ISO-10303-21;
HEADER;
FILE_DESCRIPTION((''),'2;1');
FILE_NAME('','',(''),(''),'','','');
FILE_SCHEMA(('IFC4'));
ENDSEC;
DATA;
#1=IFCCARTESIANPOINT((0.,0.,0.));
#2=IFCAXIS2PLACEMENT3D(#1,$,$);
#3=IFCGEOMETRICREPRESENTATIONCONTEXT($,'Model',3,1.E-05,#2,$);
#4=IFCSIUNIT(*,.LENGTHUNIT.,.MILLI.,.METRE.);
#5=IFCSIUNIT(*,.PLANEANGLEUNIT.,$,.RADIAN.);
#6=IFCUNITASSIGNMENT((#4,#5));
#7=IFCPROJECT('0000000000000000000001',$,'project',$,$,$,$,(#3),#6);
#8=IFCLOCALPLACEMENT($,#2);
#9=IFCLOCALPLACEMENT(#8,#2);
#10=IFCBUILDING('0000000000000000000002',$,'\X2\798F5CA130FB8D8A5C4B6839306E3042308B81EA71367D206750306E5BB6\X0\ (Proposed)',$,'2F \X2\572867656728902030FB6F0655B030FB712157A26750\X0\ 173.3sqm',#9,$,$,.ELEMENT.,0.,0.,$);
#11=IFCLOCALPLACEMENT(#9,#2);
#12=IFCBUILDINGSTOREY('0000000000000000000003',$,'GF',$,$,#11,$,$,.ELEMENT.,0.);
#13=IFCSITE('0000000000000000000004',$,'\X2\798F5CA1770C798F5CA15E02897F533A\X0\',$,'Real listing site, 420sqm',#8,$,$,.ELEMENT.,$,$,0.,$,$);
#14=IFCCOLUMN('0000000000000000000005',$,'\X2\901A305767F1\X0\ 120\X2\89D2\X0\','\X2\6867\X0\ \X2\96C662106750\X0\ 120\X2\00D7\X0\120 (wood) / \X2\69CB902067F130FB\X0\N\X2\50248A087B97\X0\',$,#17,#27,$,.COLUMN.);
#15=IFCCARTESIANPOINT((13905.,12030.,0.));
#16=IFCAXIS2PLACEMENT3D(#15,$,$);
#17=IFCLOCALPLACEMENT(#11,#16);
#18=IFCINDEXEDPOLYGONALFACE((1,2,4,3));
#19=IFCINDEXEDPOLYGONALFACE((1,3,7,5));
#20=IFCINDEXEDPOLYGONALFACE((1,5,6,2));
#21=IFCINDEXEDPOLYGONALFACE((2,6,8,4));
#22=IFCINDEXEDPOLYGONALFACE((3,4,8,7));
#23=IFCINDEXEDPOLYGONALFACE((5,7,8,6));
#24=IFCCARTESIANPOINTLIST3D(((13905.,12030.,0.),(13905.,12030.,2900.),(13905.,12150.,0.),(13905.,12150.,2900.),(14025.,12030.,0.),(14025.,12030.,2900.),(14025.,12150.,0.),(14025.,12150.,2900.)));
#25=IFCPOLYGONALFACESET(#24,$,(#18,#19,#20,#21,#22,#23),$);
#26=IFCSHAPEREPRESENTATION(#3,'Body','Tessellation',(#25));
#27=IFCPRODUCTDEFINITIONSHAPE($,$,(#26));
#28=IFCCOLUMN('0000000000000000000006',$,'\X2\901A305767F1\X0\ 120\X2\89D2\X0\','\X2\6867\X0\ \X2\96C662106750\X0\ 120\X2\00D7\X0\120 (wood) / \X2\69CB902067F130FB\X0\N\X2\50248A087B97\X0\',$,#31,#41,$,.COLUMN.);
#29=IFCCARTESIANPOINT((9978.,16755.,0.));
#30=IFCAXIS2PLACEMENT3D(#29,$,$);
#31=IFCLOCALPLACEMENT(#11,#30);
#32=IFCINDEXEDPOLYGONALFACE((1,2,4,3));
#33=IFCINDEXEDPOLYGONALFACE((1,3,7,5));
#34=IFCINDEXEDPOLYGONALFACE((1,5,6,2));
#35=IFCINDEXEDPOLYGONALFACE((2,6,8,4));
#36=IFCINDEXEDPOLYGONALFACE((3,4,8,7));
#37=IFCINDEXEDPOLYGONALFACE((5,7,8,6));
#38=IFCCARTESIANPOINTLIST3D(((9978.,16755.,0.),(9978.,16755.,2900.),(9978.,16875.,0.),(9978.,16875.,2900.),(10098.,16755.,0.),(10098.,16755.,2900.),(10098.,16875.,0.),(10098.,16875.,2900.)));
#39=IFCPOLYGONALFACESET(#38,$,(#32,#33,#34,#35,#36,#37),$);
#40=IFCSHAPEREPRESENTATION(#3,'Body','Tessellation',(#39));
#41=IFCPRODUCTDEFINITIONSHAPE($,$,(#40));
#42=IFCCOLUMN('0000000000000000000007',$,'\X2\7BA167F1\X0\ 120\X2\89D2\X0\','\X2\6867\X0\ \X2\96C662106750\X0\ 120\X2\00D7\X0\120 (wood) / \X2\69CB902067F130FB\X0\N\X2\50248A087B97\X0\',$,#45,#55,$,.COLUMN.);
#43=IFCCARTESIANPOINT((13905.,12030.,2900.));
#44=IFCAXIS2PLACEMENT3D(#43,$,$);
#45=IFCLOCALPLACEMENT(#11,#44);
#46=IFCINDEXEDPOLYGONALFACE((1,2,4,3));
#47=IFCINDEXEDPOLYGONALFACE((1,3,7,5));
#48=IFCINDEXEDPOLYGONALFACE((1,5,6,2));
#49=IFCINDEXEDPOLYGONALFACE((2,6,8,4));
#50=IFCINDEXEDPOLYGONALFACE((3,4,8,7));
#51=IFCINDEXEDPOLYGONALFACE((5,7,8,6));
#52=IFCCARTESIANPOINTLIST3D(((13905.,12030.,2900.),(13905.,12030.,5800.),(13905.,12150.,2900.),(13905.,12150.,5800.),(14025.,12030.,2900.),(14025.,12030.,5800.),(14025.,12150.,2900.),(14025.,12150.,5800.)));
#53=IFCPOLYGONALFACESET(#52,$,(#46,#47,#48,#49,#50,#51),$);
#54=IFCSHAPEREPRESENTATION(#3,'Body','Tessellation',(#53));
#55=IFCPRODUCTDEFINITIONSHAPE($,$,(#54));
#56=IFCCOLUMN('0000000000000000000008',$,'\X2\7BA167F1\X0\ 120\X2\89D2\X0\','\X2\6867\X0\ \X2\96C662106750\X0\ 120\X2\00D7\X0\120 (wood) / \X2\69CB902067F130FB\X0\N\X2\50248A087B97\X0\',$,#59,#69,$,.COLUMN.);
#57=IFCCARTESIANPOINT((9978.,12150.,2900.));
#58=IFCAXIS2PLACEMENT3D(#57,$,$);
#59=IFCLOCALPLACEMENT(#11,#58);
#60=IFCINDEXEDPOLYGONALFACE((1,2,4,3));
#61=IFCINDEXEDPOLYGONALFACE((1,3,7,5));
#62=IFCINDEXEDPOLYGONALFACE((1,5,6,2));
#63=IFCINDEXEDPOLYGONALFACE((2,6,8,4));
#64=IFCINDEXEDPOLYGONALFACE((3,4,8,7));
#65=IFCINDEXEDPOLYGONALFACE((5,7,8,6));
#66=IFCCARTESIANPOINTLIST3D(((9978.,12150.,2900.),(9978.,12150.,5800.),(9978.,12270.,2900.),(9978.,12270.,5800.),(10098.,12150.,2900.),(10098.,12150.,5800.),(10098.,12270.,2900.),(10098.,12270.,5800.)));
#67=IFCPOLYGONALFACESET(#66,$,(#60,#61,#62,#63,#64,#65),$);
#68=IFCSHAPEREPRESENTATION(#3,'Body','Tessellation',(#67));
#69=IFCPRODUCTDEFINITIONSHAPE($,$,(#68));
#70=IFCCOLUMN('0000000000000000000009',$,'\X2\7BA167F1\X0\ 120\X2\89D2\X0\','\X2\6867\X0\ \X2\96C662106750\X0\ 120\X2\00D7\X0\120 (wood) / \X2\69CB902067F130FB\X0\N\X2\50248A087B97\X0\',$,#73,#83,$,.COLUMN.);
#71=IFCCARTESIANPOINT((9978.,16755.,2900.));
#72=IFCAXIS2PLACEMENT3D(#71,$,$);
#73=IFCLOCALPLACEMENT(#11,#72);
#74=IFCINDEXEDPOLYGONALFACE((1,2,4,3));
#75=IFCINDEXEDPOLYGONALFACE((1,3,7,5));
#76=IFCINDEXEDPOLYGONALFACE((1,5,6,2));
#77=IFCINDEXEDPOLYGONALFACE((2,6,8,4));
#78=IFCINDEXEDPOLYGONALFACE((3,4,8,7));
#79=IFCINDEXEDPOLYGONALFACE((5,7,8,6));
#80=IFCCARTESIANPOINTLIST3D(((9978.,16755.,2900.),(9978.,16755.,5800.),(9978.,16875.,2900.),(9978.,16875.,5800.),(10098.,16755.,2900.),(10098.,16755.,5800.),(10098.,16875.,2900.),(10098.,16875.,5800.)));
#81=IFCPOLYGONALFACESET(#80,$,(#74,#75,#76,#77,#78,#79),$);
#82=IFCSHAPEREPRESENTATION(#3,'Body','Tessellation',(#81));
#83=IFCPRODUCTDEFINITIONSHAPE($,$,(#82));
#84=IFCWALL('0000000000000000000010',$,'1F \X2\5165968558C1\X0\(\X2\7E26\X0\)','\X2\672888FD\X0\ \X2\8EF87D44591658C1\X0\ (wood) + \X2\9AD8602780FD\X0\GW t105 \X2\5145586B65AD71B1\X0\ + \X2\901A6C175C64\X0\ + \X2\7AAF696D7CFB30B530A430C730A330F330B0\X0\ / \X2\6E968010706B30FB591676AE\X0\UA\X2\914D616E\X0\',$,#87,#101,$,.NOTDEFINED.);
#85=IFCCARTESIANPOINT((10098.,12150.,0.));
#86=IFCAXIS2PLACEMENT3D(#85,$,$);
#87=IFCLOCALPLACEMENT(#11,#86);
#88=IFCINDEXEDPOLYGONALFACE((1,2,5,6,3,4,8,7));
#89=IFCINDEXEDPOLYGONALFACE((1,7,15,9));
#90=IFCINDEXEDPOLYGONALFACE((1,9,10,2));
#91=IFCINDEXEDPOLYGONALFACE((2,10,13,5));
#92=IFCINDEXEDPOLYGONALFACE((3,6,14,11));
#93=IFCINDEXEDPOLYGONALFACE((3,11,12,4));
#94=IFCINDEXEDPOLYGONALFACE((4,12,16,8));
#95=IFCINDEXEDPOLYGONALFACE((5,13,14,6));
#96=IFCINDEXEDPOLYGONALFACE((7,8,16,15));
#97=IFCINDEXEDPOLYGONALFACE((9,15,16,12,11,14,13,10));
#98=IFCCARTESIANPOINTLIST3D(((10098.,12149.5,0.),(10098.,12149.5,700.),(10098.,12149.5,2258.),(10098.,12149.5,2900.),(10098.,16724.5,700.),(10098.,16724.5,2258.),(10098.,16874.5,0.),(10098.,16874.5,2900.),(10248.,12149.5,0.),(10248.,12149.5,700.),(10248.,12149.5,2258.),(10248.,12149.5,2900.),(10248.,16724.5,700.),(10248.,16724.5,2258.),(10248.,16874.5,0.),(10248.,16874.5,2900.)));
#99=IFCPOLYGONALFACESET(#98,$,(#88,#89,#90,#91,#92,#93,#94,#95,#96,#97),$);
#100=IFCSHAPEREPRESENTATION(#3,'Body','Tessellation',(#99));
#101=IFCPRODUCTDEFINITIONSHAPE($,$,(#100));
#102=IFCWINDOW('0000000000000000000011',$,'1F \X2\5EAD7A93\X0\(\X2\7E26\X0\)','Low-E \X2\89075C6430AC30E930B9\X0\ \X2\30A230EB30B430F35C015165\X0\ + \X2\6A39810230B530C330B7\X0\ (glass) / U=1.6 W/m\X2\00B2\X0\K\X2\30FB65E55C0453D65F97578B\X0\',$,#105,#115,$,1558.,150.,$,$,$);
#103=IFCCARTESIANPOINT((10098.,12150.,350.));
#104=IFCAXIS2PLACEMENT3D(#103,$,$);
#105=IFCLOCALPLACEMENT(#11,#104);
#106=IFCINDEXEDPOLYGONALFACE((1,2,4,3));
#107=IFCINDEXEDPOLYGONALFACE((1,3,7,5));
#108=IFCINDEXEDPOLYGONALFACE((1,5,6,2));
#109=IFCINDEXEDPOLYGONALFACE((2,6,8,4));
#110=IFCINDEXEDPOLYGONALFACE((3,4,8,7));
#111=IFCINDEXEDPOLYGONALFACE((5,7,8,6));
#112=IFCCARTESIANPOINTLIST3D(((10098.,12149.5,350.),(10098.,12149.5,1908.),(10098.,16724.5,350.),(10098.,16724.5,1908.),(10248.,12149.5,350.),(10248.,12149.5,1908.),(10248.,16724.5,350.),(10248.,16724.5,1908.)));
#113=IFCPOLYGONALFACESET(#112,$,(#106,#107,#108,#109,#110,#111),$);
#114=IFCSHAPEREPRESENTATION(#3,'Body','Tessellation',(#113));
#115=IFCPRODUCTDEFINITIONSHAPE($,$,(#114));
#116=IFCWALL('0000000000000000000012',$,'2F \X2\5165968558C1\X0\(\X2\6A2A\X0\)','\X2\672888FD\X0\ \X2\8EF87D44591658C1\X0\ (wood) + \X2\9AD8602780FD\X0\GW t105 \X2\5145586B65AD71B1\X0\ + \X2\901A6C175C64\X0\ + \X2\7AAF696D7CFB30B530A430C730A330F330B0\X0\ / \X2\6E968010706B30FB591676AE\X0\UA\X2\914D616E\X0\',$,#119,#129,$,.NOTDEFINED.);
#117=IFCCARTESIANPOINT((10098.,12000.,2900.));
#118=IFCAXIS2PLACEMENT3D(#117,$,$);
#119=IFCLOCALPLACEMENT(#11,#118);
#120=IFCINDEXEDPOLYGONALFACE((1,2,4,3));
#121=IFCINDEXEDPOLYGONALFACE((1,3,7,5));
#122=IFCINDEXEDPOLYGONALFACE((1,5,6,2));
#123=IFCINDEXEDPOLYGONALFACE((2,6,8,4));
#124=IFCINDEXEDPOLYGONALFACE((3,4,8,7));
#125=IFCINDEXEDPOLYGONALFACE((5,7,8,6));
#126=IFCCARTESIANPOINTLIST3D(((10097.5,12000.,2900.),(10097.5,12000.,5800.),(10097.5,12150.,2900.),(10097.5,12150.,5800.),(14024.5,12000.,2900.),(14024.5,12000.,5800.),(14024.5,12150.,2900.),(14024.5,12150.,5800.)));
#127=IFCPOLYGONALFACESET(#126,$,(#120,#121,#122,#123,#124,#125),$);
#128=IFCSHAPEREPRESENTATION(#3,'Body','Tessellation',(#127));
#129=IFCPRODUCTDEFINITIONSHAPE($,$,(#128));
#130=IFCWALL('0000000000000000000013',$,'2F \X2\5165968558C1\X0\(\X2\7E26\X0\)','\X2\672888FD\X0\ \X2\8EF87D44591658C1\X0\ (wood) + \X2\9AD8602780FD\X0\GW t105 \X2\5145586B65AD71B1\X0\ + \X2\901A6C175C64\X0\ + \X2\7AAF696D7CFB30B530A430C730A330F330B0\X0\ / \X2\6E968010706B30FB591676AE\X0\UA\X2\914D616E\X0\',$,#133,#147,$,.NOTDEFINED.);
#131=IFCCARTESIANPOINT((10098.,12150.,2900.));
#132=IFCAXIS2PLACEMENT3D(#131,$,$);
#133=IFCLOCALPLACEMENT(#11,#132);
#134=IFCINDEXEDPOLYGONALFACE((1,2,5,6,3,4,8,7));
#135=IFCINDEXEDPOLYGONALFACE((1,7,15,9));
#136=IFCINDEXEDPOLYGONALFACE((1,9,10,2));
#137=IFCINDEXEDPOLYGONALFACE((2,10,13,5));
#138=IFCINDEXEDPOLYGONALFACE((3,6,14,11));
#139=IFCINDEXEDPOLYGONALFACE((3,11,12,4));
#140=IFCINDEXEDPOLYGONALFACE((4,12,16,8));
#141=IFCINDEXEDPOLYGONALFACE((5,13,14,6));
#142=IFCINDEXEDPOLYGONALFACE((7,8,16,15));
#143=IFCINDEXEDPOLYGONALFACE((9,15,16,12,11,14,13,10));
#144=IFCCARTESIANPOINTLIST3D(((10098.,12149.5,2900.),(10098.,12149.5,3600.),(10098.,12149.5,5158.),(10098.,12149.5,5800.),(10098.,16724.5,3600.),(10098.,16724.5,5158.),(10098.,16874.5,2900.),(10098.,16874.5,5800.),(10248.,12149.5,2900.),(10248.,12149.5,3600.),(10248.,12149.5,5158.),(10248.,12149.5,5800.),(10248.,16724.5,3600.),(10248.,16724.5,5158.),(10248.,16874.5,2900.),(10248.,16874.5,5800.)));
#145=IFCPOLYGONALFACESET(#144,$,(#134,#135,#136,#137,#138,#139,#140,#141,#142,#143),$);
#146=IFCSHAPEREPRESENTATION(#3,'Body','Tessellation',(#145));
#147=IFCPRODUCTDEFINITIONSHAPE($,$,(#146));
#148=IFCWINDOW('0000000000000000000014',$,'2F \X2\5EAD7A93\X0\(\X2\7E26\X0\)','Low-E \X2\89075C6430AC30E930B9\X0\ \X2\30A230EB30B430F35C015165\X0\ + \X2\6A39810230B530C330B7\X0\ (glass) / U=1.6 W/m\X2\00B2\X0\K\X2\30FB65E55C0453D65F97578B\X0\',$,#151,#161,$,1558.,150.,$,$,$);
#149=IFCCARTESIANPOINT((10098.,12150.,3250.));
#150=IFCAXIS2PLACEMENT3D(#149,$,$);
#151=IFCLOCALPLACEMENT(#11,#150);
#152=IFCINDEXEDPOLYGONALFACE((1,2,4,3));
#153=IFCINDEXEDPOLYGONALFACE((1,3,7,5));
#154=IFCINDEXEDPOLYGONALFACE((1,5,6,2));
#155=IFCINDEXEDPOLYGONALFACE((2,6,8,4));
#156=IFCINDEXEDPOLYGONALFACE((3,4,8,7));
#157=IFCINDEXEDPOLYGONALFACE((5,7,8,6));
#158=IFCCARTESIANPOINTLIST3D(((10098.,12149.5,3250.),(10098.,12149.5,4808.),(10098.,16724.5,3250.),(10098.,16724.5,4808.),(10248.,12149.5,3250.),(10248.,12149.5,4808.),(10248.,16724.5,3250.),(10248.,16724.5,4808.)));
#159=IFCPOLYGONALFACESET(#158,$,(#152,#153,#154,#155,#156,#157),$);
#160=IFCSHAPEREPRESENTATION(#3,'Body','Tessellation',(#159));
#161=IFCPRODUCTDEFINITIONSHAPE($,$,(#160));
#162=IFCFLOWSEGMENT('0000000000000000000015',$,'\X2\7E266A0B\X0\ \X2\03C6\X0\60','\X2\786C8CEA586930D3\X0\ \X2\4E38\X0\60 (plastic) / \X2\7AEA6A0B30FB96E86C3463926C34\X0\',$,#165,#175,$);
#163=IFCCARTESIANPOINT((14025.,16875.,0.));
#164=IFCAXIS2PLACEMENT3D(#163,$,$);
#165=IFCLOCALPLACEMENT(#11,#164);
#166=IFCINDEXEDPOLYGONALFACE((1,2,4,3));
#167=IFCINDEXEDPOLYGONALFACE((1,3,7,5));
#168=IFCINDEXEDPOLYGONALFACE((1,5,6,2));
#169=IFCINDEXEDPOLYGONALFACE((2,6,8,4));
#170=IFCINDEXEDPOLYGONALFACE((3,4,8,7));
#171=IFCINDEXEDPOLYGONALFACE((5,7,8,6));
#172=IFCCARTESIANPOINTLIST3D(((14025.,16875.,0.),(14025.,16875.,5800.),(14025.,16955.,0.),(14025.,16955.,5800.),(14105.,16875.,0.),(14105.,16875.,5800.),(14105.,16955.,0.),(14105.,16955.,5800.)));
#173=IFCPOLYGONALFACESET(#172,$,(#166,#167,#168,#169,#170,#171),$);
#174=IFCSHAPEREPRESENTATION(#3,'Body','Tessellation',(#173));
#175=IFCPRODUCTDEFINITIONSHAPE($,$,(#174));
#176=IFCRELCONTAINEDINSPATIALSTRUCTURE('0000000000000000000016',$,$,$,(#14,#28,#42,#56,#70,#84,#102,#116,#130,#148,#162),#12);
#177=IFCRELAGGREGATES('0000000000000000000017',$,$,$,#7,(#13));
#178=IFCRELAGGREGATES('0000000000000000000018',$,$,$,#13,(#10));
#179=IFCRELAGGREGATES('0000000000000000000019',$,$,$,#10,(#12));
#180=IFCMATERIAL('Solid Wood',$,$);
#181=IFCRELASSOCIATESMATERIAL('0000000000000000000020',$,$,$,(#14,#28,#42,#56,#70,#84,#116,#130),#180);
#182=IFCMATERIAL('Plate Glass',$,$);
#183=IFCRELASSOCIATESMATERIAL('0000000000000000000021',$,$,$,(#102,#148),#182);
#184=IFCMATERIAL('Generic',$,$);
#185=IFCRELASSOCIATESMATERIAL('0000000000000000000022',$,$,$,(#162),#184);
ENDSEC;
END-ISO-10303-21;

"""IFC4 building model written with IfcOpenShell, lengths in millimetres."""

from ifc_helpers import new_model, si_unit, frame, frame_2d, origin, place, context, project, spatial, rectangle, extrude, material, element, fill, save


model = new_model("IFC4")

# Units and contexts
model_context = context("Model", 3, precision=1e-05, world=origin())
ifc_project = project(units=[si_unit("LENGTHUNIT", "METRE", prefix="MILLI"), si_unit("PLANEANGLEUNIT", "RADIAN")], contexts=[model_context])

# Site, building, storey
site_placement = place(None, origin())
site = spatial("IfcSite", under=ifc_project, at=site_placement, Name="福岡県福岡市西区", ObjectType="Real listing site, 420sqm", CompositionType="ELEMENT", RefElevation=0.0)
building_placement = place(site_placement, origin())
building = spatial("IfcBuilding", under=site, at=building_placement, Name="福岡・越屋根のある自然素材の家 (Proposed)", ObjectType="2F 在来木造・漆喰・無垢材 173.3sqm", CompositionType="ELEMENT", ElevationOfRefHeight=0.0, ElevationOfTerrain=0.0)
storey_placement = place(building_placement, origin())
storey = spatial("IfcBuildingStorey", under=building, at=storey_placement, Name="GF", CompositionType="ELEMENT", Elevation=0.0)

# Columns
ifc_material_1 = material(Name="Solid Wood")
column_1_placement = place(storey_placement, frame((13905.0, 12030.0, 0.0)))
element("IfcColumn", 1, at=column_1_placement, inside=storey, material=ifc_material_1, Name="通し柱 120角", Description="桧 集成材 120×120 (wood) / 構造柱・N値計算", PredefinedType="COLUMN", context=model_context, shape_type="SweptSolid", body=[
    extrude(rectangle(XDim=120.0, YDim=120.0, at=frame_2d((60.0, 60.0))), frame((13905.0, 12030.0, 0.0)), (0.0, 0.0, 1.0), 2900.0),
])
column_2_placement = place(storey_placement, frame((9978.0, 16755.0, 0.0)))
element("IfcColumn", 2, at=column_2_placement, inside=storey, material=ifc_material_1, Name="通し柱 120角", Description="桧 集成材 120×120 (wood) / 構造柱・N値計算", PredefinedType="COLUMN", context=model_context, shape_type="SweptSolid", body=[
    extrude(rectangle(XDim=120.0, YDim=120.0, at=frame_2d((60.0, 60.0))), frame((9978.0, 16755.0, 0.0)), (0.0, 0.0, 1.0), 2900.0),
])
column_3_placement = place(storey_placement, frame((13905.0, 12030.0, 2900.0)))
element("IfcColumn", 3, at=column_3_placement, inside=storey, material=ifc_material_1, Name="管柱 120角", Description="桧 集成材 120×120 (wood) / 構造柱・N値計算", PredefinedType="COLUMN", context=model_context, shape_type="SweptSolid", body=[
    extrude(rectangle(XDim=120.0, YDim=120.0, at=frame_2d((60.0, 60.0))), frame((13905.0, 12030.0, 2900.0)), (0.0, 0.0, 1.0), 2900.0),
])
column_4_placement = place(storey_placement, frame((9978.0, 12150.0, 2900.0)))
element("IfcColumn", 4, at=column_4_placement, inside=storey, material=ifc_material_1, Name="管柱 120角", Description="桧 集成材 120×120 (wood) / 構造柱・N値計算", PredefinedType="COLUMN", context=model_context, shape_type="SweptSolid", body=[
    extrude(rectangle(XDim=120.0, YDim=120.0, at=frame_2d((60.0, 60.0))), frame((9978.0, 12150.0, 2900.0)), (0.0, 0.0, 1.0), 2900.0),
])
column_5_placement = place(storey_placement, frame((9978.0, 16755.0, 2900.0)))
element("IfcColumn", 5, at=column_5_placement, inside=storey, material=ifc_material_1, Name="管柱 120角", Description="桧 集成材 120×120 (wood) / 構造柱・N値計算", PredefinedType="COLUMN", context=model_context, shape_type="SweptSolid", body=[
    extrude(rectangle(XDim=120.0, YDim=120.0, at=frame_2d((60.0, 60.0))), frame((9978.0, 16755.0, 2900.0)), (0.0, 0.0, 1.0), 2900.0),
])

# Wall, opening, window
wall_1_placement = place(storey_placement, frame((10098.0, 12150.0, 0.0)))
wall_1 = element("IfcWall", 6, at=wall_1_placement, inside=storey, material=ifc_material_1, Name="1F 入隅壁(縦)", Description="木製 軸組外壁 (wood) + 高性能GW t105 充填断熱 + 通気層 + 窯業系サイディング / 準耐火・外皮UA配慮", PredefinedType="NOTDEFINED", context=model_context, shape_type="SweptSolid", body=[
    extrude(rectangle(XDim=150.0, YDim=4725.0, at=frame_2d((75.0, 2362.0))), frame((10098.0, 12150.0, 0.0)), (0.0, 0.0, 1.0), 2900.0),
])
opening_1_placement = place(storey_placement, frame((10098.0, 12150.0, 350.0)))
opening_1 = element("IfcOpeningElement", 7, at=opening_1_placement, cuts=wall_1, PredefinedType="NOTDEFINED", context=model_context, shape_type="SweptSolid", body=[
    extrude(rectangle(XDim=150.0, YDim=4575.0, at=frame_2d((75.0, 2287.0))), frame((10098.0, 12150.0, 350.0)), (0.0, 0.0, 1.0), 1558.0),
])
ifc_material_2 = material(Name="Plate Glass")
window_1_placement = place(storey_placement, frame((10098.0, 12150.0, 350.0)))
window_1 = element("IfcWindow", 8, at=window_1_placement, inside=storey, material=ifc_material_2, Name="1F 庭窓(縦)", Description="Low-E 複層ガラス アルゴン封入 + 樹脂サッシ (glass) / U=1.6 W/m²K・日射取得型", OverallHeight=1558.0, OverallWidth=150.0, context=model_context, shape_type="SweptSolid", body=[
    extrude(rectangle(XDim=150.0, YDim=4575.0, at=frame_2d((75.0, 2287.0))), frame((10098.0, 12150.0, 350.0)), (0.0, 0.0, 1.0), 1558.0),
])
fill(opening_1, window_1)

# Wall
wall_2_placement = place(storey_placement, frame((10098.0, 12000.0, 2900.0)))
element("IfcWall", 9, at=wall_2_placement, inside=storey, material=ifc_material_1, Name="2F 入隅壁(横)", Description="木製 軸組外壁 (wood) + 高性能GW t105 充填断熱 + 通気層 + 窯業系サイディング / 準耐火・外皮UA配慮", PredefinedType="NOTDEFINED", context=model_context, shape_type="SweptSolid", body=[
    extrude(rectangle(XDim=3927.0, YDim=150.0, at=frame_2d((1963.0, 75.0))), frame((10098.0, 12000.0, 2900.0)), (0.0, 0.0, 1.0), 2900.0),
])

# Wall, opening, window
wall_3_placement = place(storey_placement, frame((10098.0, 12150.0, 2900.0)))
wall_3 = element("IfcWall", 10, at=wall_3_placement, inside=storey, material=ifc_material_1, Name="2F 入隅壁(縦)", Description="木製 軸組外壁 (wood) + 高性能GW t105 充填断熱 + 通気層 + 窯業系サイディング / 準耐火・外皮UA配慮", PredefinedType="NOTDEFINED", context=model_context, shape_type="SweptSolid", body=[
    extrude(rectangle(XDim=150.0, YDim=4725.0, at=frame_2d((75.0, 2362.0))), frame((10098.0, 12150.0, 2900.0)), (0.0, 0.0, 1.0), 2900.0),
])
opening_2_placement = place(storey_placement, frame((10098.0, 12150.0, 3250.0)))
opening_2 = element("IfcOpeningElement", 11, at=opening_2_placement, cuts=wall_3, PredefinedType="NOTDEFINED", context=model_context, shape_type="SweptSolid", body=[
    extrude(rectangle(XDim=150.0, YDim=4575.0, at=frame_2d((75.0, 2287.0))), frame((10098.0, 12150.0, 3250.0)), (0.0, 0.0, 1.0), 1558.0),
])
window_2_placement = place(storey_placement, frame((10098.0, 12150.0, 3250.0)))
window_2 = element("IfcWindow", 12, at=window_2_placement, inside=storey, material=ifc_material_2, Name="2F 庭窓(縦)", Description="Low-E 複層ガラス アルゴン封入 + 樹脂サッシ (glass) / U=1.6 W/m²K・日射取得型", OverallHeight=1558.0, OverallWidth=150.0, context=model_context, shape_type="SweptSolid", body=[
    extrude(rectangle(XDim=150.0, YDim=4575.0, at=frame_2d((75.0, 2287.0))), frame((10098.0, 12150.0, 3250.0)), (0.0, 0.0, 1.0), 1558.0),
])
fill(opening_2, window_2)

# Flow segment
ifc_material_3 = material(Name="Generic")
flow_segment_placement = place(storey_placement, frame((14025.0, 16875.0, 0.0)))
element("IfcFlowSegment", 13, at=flow_segment_placement, inside=storey, material=ifc_material_3, Name="縦樋 φ60", Description="硬質塩ビ 丸60 (plastic) / 竪樋・雨水排水", context=model_context, shape_type="SweptSolid", body=[
    extrude(rectangle(XDim=80.0, YDim=80.0, at=frame_2d((40.0, 40.0))), frame((14025.0, 16875.0, 0.0)), (0.0, 0.0, 1.0), 5800.0),
])

save(model, "model.ifc")
